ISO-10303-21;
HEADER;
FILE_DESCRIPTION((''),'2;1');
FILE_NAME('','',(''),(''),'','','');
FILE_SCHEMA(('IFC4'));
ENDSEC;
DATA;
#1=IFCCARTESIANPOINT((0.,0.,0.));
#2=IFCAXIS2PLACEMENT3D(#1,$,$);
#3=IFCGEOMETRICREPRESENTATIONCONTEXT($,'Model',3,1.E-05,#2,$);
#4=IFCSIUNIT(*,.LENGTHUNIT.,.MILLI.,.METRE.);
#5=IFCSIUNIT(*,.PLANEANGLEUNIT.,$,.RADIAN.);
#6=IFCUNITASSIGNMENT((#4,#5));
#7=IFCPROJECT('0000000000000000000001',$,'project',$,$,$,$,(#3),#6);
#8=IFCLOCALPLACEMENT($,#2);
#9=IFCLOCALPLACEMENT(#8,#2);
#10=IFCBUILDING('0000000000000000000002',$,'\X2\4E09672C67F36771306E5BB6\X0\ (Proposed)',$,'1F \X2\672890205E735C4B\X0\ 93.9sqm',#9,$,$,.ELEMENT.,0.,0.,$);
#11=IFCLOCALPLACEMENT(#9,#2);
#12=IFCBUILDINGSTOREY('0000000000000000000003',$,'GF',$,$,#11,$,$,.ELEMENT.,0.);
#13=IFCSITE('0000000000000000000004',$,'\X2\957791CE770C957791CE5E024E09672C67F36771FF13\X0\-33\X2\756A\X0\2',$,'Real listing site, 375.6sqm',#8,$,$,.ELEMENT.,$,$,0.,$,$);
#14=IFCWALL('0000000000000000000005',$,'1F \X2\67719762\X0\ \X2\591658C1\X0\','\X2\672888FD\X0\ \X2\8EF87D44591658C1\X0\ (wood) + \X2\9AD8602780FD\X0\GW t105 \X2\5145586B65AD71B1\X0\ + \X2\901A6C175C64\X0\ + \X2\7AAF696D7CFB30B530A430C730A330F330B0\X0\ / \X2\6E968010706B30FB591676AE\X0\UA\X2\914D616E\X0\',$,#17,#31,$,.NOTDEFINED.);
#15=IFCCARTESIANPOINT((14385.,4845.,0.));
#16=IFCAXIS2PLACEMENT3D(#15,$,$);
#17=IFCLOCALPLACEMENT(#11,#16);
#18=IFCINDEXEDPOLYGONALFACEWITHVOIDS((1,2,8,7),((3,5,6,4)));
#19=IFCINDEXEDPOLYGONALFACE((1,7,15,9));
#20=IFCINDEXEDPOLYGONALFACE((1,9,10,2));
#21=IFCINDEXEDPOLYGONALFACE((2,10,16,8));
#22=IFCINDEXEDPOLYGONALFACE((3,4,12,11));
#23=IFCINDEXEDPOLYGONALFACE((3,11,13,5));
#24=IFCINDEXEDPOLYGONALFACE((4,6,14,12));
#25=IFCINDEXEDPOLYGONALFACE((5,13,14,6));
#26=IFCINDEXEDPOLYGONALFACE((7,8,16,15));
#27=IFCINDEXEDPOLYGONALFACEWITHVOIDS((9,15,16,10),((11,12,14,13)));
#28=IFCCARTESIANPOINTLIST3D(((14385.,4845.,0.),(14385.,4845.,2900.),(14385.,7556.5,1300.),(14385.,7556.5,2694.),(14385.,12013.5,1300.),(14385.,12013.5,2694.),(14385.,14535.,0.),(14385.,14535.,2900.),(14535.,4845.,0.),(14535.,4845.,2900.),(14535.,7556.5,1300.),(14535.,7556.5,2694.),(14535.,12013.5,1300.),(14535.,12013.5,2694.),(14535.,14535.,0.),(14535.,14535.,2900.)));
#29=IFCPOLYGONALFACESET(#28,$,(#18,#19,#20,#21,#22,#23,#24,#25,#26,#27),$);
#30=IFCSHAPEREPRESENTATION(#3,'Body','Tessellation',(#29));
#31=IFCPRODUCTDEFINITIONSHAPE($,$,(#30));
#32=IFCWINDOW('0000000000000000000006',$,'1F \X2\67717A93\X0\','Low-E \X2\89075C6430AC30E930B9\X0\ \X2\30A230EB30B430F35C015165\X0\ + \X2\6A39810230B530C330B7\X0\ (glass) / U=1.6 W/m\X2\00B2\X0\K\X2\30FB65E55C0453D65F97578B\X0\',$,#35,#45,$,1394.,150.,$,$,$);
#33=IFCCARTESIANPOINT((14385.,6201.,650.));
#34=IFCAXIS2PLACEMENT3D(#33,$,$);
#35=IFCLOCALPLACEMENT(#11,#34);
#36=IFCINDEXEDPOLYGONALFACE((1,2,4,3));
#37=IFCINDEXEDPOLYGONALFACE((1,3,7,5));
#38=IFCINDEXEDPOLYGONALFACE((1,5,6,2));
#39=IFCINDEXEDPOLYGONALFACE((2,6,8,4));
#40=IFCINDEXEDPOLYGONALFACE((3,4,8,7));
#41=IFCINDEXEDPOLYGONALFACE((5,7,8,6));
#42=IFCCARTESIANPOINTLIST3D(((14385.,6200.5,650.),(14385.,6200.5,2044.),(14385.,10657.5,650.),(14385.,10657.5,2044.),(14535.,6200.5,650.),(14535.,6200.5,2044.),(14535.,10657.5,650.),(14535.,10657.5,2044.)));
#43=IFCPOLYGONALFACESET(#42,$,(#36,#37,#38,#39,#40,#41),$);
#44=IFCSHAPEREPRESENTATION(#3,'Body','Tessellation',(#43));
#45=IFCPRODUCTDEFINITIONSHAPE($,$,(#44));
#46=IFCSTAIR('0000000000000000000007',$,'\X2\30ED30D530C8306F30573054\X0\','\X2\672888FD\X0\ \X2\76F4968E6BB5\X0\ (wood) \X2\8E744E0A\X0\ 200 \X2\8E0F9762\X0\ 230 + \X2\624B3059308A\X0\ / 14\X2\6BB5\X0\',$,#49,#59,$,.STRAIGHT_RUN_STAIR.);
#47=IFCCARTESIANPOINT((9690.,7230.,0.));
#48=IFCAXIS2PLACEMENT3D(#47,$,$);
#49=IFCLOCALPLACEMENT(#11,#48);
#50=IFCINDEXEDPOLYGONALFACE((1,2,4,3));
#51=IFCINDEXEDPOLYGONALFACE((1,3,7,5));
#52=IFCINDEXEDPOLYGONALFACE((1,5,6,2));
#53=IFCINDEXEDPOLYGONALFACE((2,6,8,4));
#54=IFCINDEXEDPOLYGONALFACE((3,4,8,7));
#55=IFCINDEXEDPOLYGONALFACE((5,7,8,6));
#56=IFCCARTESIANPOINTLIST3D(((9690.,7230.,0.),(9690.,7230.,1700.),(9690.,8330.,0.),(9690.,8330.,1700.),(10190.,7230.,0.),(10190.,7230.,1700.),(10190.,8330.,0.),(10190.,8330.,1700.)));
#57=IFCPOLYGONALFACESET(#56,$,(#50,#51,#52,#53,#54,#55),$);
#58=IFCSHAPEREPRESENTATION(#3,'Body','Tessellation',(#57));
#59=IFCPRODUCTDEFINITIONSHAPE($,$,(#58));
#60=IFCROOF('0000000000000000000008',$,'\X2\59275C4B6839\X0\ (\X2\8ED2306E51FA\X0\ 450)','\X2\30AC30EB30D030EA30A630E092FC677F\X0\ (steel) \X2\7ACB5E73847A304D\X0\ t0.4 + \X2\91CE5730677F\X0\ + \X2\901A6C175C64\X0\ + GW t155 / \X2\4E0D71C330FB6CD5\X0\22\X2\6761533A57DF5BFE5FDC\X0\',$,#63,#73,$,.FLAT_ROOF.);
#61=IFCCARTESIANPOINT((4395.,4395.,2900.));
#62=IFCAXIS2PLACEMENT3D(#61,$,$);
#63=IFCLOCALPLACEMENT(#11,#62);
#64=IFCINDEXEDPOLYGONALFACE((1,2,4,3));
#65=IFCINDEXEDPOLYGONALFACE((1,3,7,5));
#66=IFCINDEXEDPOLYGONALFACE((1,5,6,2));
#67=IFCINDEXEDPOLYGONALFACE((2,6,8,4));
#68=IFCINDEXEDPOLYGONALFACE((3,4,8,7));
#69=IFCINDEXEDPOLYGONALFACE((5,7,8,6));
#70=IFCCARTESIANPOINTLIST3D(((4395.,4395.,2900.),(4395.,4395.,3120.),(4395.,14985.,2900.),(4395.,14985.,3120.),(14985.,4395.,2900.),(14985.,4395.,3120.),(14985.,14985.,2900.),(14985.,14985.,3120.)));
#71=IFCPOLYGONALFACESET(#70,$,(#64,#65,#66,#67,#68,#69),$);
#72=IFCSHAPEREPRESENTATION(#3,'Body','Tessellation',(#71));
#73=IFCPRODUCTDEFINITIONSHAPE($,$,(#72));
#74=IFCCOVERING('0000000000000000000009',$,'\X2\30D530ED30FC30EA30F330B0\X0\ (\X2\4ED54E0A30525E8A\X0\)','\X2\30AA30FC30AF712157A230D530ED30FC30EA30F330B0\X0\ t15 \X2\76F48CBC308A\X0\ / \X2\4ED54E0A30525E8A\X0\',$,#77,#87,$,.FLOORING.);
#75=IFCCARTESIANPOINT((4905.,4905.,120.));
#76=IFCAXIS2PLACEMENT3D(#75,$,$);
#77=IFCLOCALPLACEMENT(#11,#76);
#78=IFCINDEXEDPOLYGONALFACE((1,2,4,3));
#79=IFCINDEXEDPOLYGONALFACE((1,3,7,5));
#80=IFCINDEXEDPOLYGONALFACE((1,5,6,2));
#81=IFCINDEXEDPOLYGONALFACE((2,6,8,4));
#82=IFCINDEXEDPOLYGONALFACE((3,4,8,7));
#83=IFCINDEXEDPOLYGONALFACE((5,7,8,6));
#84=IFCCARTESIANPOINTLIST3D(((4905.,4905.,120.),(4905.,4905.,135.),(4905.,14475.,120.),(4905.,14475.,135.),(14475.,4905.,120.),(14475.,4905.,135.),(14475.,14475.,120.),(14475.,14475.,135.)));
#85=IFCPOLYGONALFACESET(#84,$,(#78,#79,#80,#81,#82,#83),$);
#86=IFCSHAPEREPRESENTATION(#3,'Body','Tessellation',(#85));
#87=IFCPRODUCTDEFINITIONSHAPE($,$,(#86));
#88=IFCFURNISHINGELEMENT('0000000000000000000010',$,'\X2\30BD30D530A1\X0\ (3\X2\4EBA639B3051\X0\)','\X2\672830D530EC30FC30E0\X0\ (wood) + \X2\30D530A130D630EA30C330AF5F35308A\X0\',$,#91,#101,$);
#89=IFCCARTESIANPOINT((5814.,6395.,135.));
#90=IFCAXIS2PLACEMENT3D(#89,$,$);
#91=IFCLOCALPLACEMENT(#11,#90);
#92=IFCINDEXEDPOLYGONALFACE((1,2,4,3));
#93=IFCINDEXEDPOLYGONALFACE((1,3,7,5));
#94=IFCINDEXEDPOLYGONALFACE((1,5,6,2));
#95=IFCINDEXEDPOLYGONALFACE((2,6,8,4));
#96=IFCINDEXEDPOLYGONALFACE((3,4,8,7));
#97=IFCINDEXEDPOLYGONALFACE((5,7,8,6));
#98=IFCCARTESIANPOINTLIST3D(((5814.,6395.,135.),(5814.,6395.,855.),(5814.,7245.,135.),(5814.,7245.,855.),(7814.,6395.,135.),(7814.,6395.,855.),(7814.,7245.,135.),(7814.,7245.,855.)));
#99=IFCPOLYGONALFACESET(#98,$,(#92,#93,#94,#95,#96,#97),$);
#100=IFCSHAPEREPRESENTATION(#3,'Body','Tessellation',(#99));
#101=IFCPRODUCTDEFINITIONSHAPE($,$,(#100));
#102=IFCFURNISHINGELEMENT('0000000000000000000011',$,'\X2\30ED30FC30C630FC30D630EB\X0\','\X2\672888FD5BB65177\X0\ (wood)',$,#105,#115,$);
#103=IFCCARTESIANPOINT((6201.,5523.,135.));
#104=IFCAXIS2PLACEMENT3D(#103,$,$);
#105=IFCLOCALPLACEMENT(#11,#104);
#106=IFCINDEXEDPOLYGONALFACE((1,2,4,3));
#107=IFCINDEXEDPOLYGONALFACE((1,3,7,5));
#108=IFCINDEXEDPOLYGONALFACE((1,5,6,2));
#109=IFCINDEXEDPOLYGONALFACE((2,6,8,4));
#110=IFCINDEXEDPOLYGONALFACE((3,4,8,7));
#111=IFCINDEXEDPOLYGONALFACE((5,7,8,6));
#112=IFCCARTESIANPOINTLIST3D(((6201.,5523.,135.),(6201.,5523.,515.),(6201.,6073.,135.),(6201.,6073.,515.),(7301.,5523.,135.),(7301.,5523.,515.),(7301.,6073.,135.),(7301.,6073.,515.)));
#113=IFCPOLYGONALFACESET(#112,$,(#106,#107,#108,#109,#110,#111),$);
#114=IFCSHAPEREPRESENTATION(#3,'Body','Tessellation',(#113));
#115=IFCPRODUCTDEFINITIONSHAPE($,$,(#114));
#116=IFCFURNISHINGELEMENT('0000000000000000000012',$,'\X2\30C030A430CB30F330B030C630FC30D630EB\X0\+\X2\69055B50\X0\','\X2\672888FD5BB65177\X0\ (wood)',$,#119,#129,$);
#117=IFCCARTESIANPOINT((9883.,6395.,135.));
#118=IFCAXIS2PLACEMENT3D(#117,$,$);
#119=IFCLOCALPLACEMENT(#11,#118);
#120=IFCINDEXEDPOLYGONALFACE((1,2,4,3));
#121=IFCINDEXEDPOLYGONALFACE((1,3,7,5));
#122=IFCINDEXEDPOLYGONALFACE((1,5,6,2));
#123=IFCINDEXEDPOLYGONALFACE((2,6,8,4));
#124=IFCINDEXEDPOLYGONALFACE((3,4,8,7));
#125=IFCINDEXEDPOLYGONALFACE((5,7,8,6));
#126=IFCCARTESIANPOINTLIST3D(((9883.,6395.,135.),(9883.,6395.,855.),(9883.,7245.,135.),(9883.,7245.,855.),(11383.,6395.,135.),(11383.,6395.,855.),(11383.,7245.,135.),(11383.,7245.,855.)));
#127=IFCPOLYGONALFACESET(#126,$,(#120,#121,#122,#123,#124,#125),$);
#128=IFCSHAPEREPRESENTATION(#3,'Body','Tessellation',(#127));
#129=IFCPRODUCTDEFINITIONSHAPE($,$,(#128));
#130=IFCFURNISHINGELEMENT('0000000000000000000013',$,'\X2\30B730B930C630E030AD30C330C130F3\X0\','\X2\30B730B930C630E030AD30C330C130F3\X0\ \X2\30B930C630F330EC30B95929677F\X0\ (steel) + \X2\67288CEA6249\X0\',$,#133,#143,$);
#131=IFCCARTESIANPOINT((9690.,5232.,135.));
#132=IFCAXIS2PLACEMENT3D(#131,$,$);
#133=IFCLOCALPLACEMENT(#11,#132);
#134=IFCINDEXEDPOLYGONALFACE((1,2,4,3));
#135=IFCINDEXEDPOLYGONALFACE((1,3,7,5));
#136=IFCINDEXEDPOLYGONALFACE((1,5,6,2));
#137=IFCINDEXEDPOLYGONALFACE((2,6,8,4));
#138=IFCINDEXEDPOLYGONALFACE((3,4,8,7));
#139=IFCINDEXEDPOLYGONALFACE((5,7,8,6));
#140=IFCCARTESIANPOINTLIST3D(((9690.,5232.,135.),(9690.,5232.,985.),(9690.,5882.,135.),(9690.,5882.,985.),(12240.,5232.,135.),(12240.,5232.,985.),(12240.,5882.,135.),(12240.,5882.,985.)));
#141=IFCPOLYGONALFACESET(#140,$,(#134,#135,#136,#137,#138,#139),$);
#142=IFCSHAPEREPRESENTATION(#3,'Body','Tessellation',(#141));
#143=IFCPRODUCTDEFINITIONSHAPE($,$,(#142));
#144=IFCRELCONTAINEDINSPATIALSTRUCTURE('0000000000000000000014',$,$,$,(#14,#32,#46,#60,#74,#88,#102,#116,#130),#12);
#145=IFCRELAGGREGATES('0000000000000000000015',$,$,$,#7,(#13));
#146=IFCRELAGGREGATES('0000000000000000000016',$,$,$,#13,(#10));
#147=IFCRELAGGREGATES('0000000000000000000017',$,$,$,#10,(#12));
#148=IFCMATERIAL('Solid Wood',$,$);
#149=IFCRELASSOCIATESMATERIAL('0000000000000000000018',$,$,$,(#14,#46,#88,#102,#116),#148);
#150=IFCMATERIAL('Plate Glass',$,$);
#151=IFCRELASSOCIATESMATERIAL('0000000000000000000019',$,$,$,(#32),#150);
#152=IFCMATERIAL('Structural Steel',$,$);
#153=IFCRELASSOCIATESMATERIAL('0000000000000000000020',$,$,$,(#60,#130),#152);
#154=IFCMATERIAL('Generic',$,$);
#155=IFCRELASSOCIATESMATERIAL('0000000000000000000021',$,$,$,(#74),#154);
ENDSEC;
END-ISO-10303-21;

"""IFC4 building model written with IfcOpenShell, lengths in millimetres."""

from ifc_helpers import new_model, si_unit, frame, frame_2d, origin, place, context, project, spatial, rectangle, extrude, material, element, fill, save


model = new_model("IFC4")

# Units and contexts
model_context = context("Model", 3, precision=1e-05, world=origin())
ifc_project = project(units=[si_unit("LENGTHUNIT", "METRE", prefix="MILLI"), si_unit("PLANEANGLEUNIT", "RADIAN")], contexts=[model_context])

# Site, building, storey
site_placement = place(None, origin())
site = spatial("IfcSite", under=ifc_project, at=site_placement, Name="長野県長野市三本柳東３-33番2", ObjectType="Real listing site, 375.6sqm", CompositionType="ELEMENT", RefElevation=0.0)
building_placement = place(site_placement, origin())
building = spatial("IfcBuilding", under=site, at=building_placement, Name="三本柳東の家 (Proposed)", ObjectType="1F 木造平屋 93.9sqm", CompositionType="ELEMENT", ElevationOfRefHeight=0.0, ElevationOfTerrain=0.0)
storey_placement = place(building_placement, origin())
storey = spatial("IfcBuildingStorey", under=building, at=storey_placement, Name="GF", CompositionType="ELEMENT", Elevation=0.0)

# Shared definitions
ifc_material_1 = material(Name="Solid Wood")

# Shared definitions
ifc_material_2 = material(Name="Plate Glass")

# Wall, opening, window
wall_1_placement = place(storey_placement, frame((14385.0, 4845.0, 0.0)))
wall_1 = element("IfcWall", 1, at=wall_1_placement, inside=storey, material=ifc_material_1, Name="1F 東面 外壁", Description="木製 軸組外壁 (wood) + 高性能GW t105 充填断熱 + 通気層 + 窯業系サイディング / 準耐火・外皮UA配慮", PredefinedType="NOTDEFINED", context=model_context, shape_type="SweptSolid", body=[
    extrude(rectangle(XDim=150.0, YDim=9690.0, at=frame_2d((75.0, 4845.0))), frame((14385.0, 4845.0, 0.0)), (0.0, 0.0, 1.0), 2900.0),
])
opening_1_placement = place(storey_placement, frame((14385.0, 6201.0, 650.0)))
opening_1 = element("IfcOpeningElement", 2, at=opening_1_placement, cuts=wall_1, PredefinedType="NOTDEFINED", context=model_context, shape_type="SweptSolid", body=[
    extrude(rectangle(XDim=150.0, YDim=4457.0, at=frame_2d((75.0, 2228.0))), frame((14385.0, 6201.0, 650.0)), (0.0, 0.0, 1.0), 1394.0),
])
window_1_placement = place(storey_placement, frame((14385.0, 6201.0, 650.0)))
window_1 = element("IfcWindow", 3, at=window_1_placement, inside=storey, material=ifc_material_2, Name="1F 東窓", Description="Low-E 複層ガラス アルゴン封入 + 樹脂サッシ (glass) / U=1.6 W/m²K・日射取得型", OverallHeight=1394.0, OverallWidth=150.0, context=model_context, shape_type="SweptSolid", body=[
    extrude(rectangle(XDim=150.0, YDim=4457.0, at=frame_2d((75.0, 2228.0))), frame((14385.0, 6201.0, 650.0)), (0.0, 0.0, 1.0), 1394.0),
])
fill(opening_1, window_1)

# Stair
stair_placement = place(storey_placement, frame((9690.0, 7230.0, 0.0)))
element("IfcStair", 4, at=stair_placement, inside=storey, material=ifc_material_1, Name="ロフトはしご", Description="木製 直階段 (wood) 蹴上 200 踏面 230 + 手すり / 14段", PredefinedType="STRAIGHT_RUN_STAIR", context=model_context, shape_type="SweptSolid", body=[
    extrude(rectangle(XDim=500.0, YDim=1100.0, at=frame_2d((250.0, 550.0))), frame((9690.0, 7230.0, 0.0)), (0.0, 0.0, 1.0), 1700.0),
])

# Roof
ifc_material_3 = material(Name="Structural Steel")
roof_placement = place(storey_placement, frame((4395.0, 4395.0, 2900.0)))
element("IfcRoof", 5, at=roof_placement, inside=storey, material=ifc_material_3, Name="大屋根 (軒の出 450)", Description="ガルバリウム鋼板 (steel) 立平葺き t0.4 + 野地板 + 通気層 + GW t155 / 不燃・法22条区域対応", PredefinedType="FLAT_ROOF", context=model_context, shape_type="SweptSolid", body=[
    extrude(rectangle(XDim=10590.0, YDim=10590.0, at=frame_2d((5295.0, 5295.0))), frame((4395.0, 4395.0, 2900.0)), (0.0, 0.0, 1.0), 220.0),
])

# Covering
ifc_material_4 = material(Name="Generic")
covering_placement = place(storey_placement, frame((4905.0, 4905.0, 120.0)))
element("IfcCovering", 6, at=covering_placement, inside=storey, material=ifc_material_4, Name="フローリング (仕上げ床)", Description="オーク無垢フローリング t15 直貼り / 仕上げ床", PredefinedType="FLOORING", context=model_context, shape_type="SweptSolid", body=[
    extrude(rectangle(XDim=9570.0, YDim=9570.0, at=frame_2d((4785.0, 4785.0))), frame((4905.0, 4905.0, 120.0)), (0.0, 0.0, 1.0), 15.0),
])

# Furnishing elements
furnishing_1_placement = place(storey_placement, frame((5814.0, 6395.0, 135.0)))
element("IfcFurnishingElement", 7, at=furnishing_1_placement, inside=storey, material=ifc_material_1, Name="ソファ (3人掛け)", Description="木フレーム (wood) + ファブリック張り", context=model_context, shape_type="SweptSolid", body=[
    extrude(rectangle(XDim=2000.0, YDim=850.0, at=frame_2d((1000.0, 425.0))), frame((5814.0, 6395.0, 135.0)), (0.0, 0.0, 1.0), 720.0),
])
furnishing_2_placement = place(storey_placement, frame((6201.0, 5523.0, 135.0)))
element("IfcFurnishingElement", 8, at=furnishing_2_placement, inside=storey, material=ifc_material_1, Name="ローテーブル", Description="木製家具 (wood)", context=model_context, shape_type="SweptSolid", body=[
    extrude(rectangle(XDim=1100.0, YDim=550.0, at=frame_2d((550.0, 275.0))), frame((6201.0, 5523.0, 135.0)), (0.0, 0.0, 1.0), 380.0),
])
furnishing_3_placement = place(storey_placement, frame((9883.0, 6395.0, 135.0)))
element("IfcFurnishingElement", 9, at=furnishing_3_placement, inside=storey, material=ifc_material_1, Name="ダイニングテーブル+椅子", Description="木製家具 (wood)", context=model_context, shape_type="SweptSolid", body=[
    extrude(rectangle(XDim=1500.0, YDim=850.0, at=frame_2d((750.0, 425.0))), frame((9883.0, 6395.0, 135.0)), (0.0, 0.0, 1.0), 720.0),
])
furnishing_4_placement = place(storey_placement, frame((9690.0, 5232.0, 135.0)))
element("IfcFurnishingElement", 10, at=furnishing_4_placement, inside=storey, material=ifc_material_3, Name="システムキッチン", Description="システムキッチン ステンレス天板 (steel) + 木質扉", context=model_context, shape_type="SweptSolid", body=[
    extrude(rectangle(XDim=2550.0, YDim=650.0, at=frame_2d((1275.0, 325.0))), frame((9690.0, 5232.0, 135.0)), (0.0, 0.0, 1.0), 850.0),
])

save(model, "model.ifc")
